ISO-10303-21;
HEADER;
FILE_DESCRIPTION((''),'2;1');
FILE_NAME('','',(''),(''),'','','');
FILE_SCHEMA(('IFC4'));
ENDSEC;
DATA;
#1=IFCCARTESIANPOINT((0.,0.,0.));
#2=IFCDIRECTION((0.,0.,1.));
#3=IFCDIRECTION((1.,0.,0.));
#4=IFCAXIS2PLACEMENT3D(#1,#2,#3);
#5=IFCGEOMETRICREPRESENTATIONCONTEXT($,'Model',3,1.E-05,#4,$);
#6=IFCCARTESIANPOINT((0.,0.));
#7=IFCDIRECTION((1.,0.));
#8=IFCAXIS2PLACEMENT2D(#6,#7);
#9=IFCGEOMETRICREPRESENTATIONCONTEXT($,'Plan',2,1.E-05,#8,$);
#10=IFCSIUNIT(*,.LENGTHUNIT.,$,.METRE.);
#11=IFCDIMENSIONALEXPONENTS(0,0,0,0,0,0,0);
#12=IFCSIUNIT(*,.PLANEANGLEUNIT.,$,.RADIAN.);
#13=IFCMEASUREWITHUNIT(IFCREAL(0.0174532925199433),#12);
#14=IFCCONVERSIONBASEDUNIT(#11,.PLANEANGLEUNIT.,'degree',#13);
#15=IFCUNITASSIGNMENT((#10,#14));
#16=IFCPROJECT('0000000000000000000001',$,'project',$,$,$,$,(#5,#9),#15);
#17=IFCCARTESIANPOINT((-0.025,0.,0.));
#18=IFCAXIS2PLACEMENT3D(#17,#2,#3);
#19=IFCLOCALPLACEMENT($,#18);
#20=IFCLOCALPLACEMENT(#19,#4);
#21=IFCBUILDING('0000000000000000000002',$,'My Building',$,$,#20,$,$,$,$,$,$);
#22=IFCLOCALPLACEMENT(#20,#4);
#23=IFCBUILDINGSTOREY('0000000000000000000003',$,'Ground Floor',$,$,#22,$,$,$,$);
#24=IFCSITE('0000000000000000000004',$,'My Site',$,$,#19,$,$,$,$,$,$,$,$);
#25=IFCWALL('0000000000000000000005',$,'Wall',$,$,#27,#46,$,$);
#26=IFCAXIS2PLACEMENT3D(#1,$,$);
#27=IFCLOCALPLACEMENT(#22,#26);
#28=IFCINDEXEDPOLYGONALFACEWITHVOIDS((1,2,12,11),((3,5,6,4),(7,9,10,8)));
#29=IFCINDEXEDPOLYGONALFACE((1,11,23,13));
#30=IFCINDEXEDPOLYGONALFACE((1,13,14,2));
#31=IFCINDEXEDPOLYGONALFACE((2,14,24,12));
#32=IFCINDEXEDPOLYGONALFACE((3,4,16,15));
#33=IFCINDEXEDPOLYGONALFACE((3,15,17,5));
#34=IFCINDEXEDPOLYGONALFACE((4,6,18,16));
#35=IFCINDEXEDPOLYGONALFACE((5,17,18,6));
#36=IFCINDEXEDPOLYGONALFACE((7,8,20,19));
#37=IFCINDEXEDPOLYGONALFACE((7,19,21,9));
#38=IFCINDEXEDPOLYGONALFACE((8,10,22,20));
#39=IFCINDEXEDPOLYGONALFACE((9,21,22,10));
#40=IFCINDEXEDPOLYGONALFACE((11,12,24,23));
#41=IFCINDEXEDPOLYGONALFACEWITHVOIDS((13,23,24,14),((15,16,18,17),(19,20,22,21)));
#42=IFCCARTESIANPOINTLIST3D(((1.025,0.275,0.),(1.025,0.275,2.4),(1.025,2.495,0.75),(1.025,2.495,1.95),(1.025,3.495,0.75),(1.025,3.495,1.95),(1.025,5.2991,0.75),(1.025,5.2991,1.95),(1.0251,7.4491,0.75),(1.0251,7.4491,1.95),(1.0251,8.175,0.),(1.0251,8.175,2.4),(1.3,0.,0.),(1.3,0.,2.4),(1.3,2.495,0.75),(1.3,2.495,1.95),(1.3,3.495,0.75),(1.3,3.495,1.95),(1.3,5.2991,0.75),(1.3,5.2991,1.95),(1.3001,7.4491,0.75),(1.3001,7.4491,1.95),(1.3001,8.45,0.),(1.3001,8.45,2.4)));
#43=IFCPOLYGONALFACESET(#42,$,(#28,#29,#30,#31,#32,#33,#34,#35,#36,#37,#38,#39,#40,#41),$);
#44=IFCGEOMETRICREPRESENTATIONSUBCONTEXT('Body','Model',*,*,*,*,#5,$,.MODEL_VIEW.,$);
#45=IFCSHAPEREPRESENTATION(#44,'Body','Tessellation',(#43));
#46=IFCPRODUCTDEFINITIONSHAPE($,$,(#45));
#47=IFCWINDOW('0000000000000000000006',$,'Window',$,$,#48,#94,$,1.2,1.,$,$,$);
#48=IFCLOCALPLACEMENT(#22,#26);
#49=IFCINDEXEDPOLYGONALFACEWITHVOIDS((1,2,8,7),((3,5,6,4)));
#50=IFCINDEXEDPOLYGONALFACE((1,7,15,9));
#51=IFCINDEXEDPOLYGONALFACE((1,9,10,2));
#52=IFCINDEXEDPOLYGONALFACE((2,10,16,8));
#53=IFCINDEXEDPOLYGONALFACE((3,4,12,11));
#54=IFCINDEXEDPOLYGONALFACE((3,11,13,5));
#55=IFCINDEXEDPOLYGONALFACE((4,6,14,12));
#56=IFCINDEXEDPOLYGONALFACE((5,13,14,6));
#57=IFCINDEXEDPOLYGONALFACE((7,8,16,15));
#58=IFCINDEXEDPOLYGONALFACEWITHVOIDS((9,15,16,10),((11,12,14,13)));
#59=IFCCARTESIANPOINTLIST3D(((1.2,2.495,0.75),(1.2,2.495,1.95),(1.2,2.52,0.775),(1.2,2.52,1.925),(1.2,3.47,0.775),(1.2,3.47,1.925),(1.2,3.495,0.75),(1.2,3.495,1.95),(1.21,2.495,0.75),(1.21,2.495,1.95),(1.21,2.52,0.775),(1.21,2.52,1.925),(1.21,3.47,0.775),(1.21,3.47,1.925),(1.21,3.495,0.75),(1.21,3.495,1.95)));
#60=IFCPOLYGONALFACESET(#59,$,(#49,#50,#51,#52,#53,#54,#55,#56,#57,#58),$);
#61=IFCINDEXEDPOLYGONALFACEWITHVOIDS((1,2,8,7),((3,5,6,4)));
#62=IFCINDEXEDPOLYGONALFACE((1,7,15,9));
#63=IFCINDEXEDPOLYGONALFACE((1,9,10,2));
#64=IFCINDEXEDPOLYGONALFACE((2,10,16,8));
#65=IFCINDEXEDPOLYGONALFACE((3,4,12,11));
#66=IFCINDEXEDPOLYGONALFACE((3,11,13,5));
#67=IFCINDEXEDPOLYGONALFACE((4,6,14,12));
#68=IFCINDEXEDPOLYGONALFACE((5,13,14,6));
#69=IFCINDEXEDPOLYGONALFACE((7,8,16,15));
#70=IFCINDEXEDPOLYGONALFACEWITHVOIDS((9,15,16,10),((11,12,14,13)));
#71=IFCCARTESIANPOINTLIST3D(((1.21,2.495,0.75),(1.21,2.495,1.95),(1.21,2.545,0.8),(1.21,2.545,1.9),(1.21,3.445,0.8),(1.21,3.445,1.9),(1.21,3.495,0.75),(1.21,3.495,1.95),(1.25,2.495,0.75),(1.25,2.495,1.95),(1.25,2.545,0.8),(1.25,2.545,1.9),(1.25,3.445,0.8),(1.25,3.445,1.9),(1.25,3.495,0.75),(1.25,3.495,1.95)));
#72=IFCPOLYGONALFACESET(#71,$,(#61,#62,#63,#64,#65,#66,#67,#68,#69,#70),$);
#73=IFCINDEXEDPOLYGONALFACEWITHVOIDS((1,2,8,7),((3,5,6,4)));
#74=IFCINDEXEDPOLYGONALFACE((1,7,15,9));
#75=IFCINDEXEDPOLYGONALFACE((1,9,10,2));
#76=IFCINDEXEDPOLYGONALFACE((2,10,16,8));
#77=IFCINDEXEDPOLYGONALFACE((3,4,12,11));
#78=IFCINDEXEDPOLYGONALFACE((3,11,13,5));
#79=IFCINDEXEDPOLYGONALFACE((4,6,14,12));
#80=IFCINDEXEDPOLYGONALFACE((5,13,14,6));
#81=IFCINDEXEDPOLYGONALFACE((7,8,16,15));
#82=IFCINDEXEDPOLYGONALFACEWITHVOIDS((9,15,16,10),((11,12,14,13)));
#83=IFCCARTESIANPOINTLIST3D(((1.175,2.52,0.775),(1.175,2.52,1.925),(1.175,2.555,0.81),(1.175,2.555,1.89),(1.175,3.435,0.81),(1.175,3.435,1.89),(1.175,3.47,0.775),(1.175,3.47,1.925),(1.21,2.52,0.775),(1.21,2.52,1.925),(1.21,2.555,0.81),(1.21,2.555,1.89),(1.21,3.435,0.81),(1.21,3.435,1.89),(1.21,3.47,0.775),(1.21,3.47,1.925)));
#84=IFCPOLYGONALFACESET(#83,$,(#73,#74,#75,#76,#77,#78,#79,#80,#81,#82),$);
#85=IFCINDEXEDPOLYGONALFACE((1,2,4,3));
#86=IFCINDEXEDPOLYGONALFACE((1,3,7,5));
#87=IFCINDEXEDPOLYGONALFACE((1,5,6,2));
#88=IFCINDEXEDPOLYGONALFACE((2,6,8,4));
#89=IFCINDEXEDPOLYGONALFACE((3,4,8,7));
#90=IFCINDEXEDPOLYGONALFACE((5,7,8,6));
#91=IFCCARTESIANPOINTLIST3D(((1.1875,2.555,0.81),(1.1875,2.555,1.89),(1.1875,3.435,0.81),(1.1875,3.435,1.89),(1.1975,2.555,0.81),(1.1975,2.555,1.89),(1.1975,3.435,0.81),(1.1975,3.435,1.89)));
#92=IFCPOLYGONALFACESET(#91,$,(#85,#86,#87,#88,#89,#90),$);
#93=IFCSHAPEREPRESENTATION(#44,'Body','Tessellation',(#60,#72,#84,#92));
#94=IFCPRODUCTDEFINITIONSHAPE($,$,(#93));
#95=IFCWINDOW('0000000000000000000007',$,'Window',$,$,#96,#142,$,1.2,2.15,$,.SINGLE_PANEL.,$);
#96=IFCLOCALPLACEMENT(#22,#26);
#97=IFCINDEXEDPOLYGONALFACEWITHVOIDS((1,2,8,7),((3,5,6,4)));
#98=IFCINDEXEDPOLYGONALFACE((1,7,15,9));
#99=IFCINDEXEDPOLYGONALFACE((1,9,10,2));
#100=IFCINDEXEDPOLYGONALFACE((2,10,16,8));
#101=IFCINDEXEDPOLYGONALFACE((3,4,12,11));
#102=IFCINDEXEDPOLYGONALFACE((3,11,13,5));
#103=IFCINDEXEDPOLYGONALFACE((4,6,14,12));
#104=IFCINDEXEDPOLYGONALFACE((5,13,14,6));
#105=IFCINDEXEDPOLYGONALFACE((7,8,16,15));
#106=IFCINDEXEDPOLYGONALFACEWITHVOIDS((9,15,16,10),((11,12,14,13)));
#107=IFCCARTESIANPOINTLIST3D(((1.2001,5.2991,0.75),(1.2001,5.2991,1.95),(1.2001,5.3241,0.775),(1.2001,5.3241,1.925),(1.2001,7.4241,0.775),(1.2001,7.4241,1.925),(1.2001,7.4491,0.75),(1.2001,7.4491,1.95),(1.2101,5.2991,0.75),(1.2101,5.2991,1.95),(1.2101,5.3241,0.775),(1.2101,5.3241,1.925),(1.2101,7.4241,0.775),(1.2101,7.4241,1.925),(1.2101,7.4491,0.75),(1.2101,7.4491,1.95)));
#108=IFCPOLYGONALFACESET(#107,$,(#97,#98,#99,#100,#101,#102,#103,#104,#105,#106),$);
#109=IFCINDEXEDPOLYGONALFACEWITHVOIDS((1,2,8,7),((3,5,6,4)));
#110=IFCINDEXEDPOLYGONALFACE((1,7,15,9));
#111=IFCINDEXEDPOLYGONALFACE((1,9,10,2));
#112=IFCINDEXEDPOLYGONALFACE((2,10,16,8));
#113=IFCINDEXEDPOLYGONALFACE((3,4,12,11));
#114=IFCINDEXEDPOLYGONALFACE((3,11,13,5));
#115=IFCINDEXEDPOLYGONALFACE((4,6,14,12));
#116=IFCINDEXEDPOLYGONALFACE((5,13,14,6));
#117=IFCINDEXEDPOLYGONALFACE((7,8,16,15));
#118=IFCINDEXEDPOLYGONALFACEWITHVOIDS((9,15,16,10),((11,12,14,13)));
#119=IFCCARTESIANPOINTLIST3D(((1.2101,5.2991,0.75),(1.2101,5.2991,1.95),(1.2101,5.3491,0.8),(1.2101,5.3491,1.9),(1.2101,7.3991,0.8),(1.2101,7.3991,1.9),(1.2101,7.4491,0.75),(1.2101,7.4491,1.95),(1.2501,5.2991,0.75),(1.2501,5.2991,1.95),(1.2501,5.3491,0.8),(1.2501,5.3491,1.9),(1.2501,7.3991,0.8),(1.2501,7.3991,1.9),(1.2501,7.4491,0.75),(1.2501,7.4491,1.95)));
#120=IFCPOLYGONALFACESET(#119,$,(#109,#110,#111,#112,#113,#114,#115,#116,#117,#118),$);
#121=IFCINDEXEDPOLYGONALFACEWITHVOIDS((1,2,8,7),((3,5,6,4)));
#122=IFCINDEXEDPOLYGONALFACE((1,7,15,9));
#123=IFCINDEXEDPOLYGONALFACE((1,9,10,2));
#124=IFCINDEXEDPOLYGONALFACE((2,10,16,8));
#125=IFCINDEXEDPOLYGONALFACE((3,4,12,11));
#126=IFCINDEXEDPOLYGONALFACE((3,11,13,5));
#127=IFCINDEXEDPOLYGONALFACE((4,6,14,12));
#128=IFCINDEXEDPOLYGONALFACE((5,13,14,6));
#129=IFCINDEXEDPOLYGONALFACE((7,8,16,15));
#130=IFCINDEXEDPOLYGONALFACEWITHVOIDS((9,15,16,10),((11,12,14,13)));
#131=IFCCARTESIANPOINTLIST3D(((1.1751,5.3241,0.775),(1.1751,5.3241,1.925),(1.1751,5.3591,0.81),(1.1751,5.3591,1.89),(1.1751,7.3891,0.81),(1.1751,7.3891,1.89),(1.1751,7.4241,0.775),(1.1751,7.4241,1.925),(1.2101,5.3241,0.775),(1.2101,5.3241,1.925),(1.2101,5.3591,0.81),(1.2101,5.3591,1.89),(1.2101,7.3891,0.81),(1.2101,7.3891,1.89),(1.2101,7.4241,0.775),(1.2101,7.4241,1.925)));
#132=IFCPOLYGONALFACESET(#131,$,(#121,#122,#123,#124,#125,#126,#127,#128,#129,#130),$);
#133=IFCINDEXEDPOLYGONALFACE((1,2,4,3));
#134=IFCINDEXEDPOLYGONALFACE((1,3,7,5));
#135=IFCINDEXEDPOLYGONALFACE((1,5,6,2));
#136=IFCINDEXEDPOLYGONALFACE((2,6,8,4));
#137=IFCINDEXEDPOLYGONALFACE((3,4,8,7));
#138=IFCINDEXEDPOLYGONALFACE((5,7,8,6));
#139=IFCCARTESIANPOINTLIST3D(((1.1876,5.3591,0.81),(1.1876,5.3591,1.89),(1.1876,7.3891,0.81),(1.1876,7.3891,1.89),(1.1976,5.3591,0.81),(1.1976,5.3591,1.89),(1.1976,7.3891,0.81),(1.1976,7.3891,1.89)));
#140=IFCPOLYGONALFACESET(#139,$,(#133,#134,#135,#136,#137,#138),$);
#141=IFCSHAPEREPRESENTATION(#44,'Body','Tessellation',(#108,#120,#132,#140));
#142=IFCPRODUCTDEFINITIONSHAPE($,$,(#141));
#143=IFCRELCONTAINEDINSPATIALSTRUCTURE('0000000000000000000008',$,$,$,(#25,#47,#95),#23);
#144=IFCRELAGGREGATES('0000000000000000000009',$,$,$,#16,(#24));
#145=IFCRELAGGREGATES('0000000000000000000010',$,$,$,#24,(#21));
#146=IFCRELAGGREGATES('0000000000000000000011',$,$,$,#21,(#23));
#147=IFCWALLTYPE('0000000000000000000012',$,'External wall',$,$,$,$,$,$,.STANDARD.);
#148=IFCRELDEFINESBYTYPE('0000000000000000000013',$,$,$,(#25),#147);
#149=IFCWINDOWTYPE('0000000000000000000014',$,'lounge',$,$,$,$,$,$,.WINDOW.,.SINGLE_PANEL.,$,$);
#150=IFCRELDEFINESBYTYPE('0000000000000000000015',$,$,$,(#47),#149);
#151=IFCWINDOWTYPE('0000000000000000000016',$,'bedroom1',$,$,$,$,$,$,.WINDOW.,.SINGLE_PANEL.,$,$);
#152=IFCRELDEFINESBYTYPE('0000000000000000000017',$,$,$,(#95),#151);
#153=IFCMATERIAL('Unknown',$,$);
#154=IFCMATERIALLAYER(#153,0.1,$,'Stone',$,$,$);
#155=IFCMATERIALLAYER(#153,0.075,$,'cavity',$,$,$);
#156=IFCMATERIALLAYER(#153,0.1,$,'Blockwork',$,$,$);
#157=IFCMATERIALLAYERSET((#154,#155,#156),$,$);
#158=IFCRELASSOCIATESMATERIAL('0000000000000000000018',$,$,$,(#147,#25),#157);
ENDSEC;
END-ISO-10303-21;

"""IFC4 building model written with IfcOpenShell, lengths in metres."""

from ifc_helpers import new_model, entity, si_unit, converted_unit, frame, origin_with_axes, origin_2d_with_axis, place, context, subcontext, project, spatial, line, indexed_curve, outline, extrude, clip, halfspace, shape, source, transform, mapped, material, layer, layer_set, layer_usage, type_object, type_shapes, element, fill, save


model = new_model("IFC4")

# Units and contexts
model_context = context("Model", 3, precision=1e-05, world=origin_with_axes())
plan_context = context("Plan", 2, precision=1e-05, world=origin_2d_with_axis())
body_context_1 = subcontext(model_context, "Body", "Model", "MODEL_VIEW")
body_context_2 = subcontext(plan_context, "Body", "Plan", "PLAN_VIEW")
ifc_project = project(units=[si_unit("LENGTHUNIT", "METRE"), converted_unit("PLANEANGLEUNIT", "degree", entity("IfcReal", 0.0174532925199433), si_unit("PLANEANGLEUNIT", "RADIAN"), dimensions=[0, 0, 0, 0, 0, 0, 0])], contexts=[model_context, plan_context])

# Site, building, storey
site_placement = place(None, frame((-0.025, 0.0, 0.0), z_axis=(0.0, 0.0, 1.0), x_axis=(1.0, 0.0, 0.0)))
site = spatial("IfcSite", under=ifc_project, at=site_placement, Name="My Site")
building_placement = place(site_placement, origin_with_axes())
building = spatial("IfcBuilding", under=site, at=building_placement, Name="My Building")
storey_placement = place(building_placement, frame((0.0, 0.0, 0.0), z_axis=(0.0, 0.0, 1.0), x_axis=(1.0, 0.0, 0.0)))
storey = spatial("IfcBuildingStorey", under=building, at=storey_placement, Name="Ground Floor")

# Shared definitions
ifc_material = material(Name="Unknown")
ifc_layer_1 = layer(ifc_material, 0.1, Name="Stone")
ifc_layer_2 = layer(ifc_material, 0.075, Name="cavity")
ifc_layer_3 = layer(ifc_material, 0.1, Name="Blockwork")
ifc_layer_set_1 = layer_set([ifc_layer_1, ifc_layer_2, ifc_layer_3])
wall_type_1 = type_object("IfcWallType", Name="External wall", PredefinedType="STANDARD", material=ifc_layer_set_1)

# Wall, openings, windows
ifc_layer_usage_1 = layer_usage(ifc_layer_set_1, "AXIS2", "POSITIVE", 0.0)
wall_1_placement = place(storey_placement, frame((1.3, 0.0, 0.0), z_axis=(0.0, 0.0, 1.0), x_axis=(0.0, 1.0, 0.0)))
wall_1 = element("IfcWall", 1, at=wall_1_placement, inside=storey, type_object=wall_type_1, material=ifc_layer_usage_1, Name="Wall", context=body_context_1, shape_type="Clipping", body=[
    clip(clip(extrude(outline(indexed_curve([(0.0, 0.0), (0.0, 0.275), (8.45, 0.275), (8.45, 0.0), (0.0, 0.0)], self_intersect=False)), origin_with_axes(), (0.0, 0.0, 1.0), 2.4), halfspace(frame((0.0, 0.0, 0.0), z_axis=(-0.707107, 0.707107, 0.0), x_axis=(0.707107, 0.707107, 0.0)), False)), halfspace(frame((8.45, 0.0, 0.0), z_axis=(0.707107, 0.707106, 0.0), x_axis=(-0.707106, 0.707107, 0.0)), False)),
])
shared_shape_1 = source(origin_with_axes(), body_context_1, "Body", "SweptSolid", [
    extrude(outline(indexed_curve([(0.0, 0.0), (1.0, 0.0), (1.0, 1.2), (0.0, 1.2)], segments=[line(1, 2, 3, 4, 1)])), frame((0.0, -0.6, 0.0), z_axis=(0.0, -1.0, 0.0), x_axis=(1.0, 0.0, 0.0)), (0.0, 0.0, -1.0), 1.2),
])
opening_1_placement = place(wall_1_placement, frame((2.495, 0.0, 0.75), z_axis=(0.0, 0.0, 1.0), x_axis=(1.0, 0.0, 0.0)))
opening_1 = element("IfcOpeningElement", 2, at=opening_1_placement, cuts=wall_1, PredefinedType="OPENING", context=body_context_1, shape_type="MappedRepresentation", body=[
    mapped(shared_shape_1, transform((0.0, 0.0, 0.0), x_axis=(1.0, 0.0, 0.0), y_axis=(0.0, 1.0, 0.0), z_axis=(0.0, 0.0, 1.0), scale=1.0)),
])
shared_shape_2 = source(origin_with_axes(), body_context_1, "Body", "SweptSolid", [
    extrude(outline(indexed_curve([(0.0, 0.0), (2.15, 0.0), (2.15, 1.2), (0.0, 1.2)], segments=[line(1, 2, 3, 4, 1)])), frame((0.0, -0.1, 0.0), z_axis=(0.0, -1.0, 0.0), x_axis=(1.0, 0.0, 0.0)), (0.0, 0.0, -1.0), 0.475),
])
opening_2_placement = place(wall_1_placement, frame((5.2991, 0.0, 0.75), z_axis=(0.0, 0.0, 1.0), x_axis=(1.0, 0.0, 0.0)))
opening_2 = element("IfcOpeningElement", 3, at=opening_2_placement, cuts=wall_1, PredefinedType="OPENING", context=body_context_1, shape_type="MappedRepresentation", body=[
    mapped(shared_shape_2, transform((0.0, 0.0, 0.0), x_axis=(1.0, 0.0, 0.0), y_axis=(0.0, 1.0, 0.0), z_axis=(0.0, 0.0, 1.0), scale=1.0)),
])
window_type_1 = type_object("IfcWindowType", Name="lounge", PartitioningType="SINGLE_PANEL", PredefinedType="WINDOW")
shared_shape_3 = source(origin_with_axes(), body_context_1, "Body", "SweptSolid", [
    extrude(outline(indexed_curve([(0.0, 0.0), (1.0, 0.0), (1.0, 1.2), (0.0, 1.2)], segments=[line(1, 2, 3, 4, 1)]), holes=[indexed_curve([(0.025, 0.025), (0.975, 0.025), (0.975, 1.175), (0.025, 1.175)], segments=[line(1, 2, 3, 4, 1)])]), frame((0.0, 0.09, 0.0), z_axis=(0.0, -1.0, 0.0), x_axis=(1.0, 0.0, 0.0)), (0.0, 0.0, -1.0), 0.01),
    extrude(outline(indexed_curve([(0.0, 0.0), (1.0, 0.0), (1.0, 1.2), (0.0, 1.2)], segments=[line(1, 2, 3, 4, 1)]), holes=[indexed_curve([(0.05, 0.05), (0.95, 0.05), (0.95, 1.15), (0.05, 1.15)], segments=[line(1, 2, 3, 4, 1)])]), frame((0.0, 0.05, 0.0), z_axis=(0.0, -1.0, 0.0), x_axis=(1.0, 0.0, 0.0)), (0.0, 0.0, -1.0), 0.04),
    extrude(outline(indexed_curve([(0.0, 0.0), (0.95, 0.0), (0.95, 1.15), (0.0, 1.15)], segments=[line(1, 2, 3, 4, 1)]), holes=[indexed_curve([(0.035, 0.035), (0.915, 0.035), (0.915, 1.115), (0.035, 1.115)], segments=[line(1, 2, 3, 4, 1)])]), frame((0.025, 0.09, 0.025), z_axis=(0.0, -1.0, 0.0), x_axis=(1.0, 0.0, 0.0)), (0.0, 0.0, -1.0), 0.035),
    extrude(outline(indexed_curve([(0.035, 0.035), (0.915, 0.035), (0.915, 1.115), (0.035, 1.115)], segments=[line(1, 2, 3, 4, 1)])), frame((0.025, 0.1025, 0.025), z_axis=(0.0, -1.0, 0.0), x_axis=(1.0, 0.0, 0.0)), (0.0, 0.0, -1.0), 0.01),
])
shared_shape_4 = source(origin_with_axes(), body_context_2, "Body", "Curve2D", [
    entity("IfcIndexedPolyCurve", entity("IfcCartesianPointList2D", [[0.05, 0.05], [0.95, 0.05]])),
    entity("IfcIndexedPolyCurve", entity("IfcCartesianPointList2D", [[0.0, 0.1], [0.025, 0.1], [0.025, 0.09], [0.05, 0.09], [0.05, 0.05], [0.0, 0.05]]), [entity("IfcLineIndex", [1, 2, 3, 4, 5, 6, 1])]),
    entity("IfcIndexedPolyCurve", entity("IfcCartesianPointList2D", [[1.0, 0.1], [0.975, 0.1], [0.975, 0.09], [0.95, 0.09], [0.95, 0.05], [1.0, 0.05]]), [entity("IfcLineIndex", [1, 2, 3, 4, 5, 6, 1])]),
    entity("IfcIndexedPolyCurve", entity("IfcCartesianPointList2D", [[0.025, 0.09], [0.06, 0.09], [0.06, 0.125], [0.025, 0.125]]), [entity("IfcLineIndex", [1, 2, 3, 4, 1])]),
    entity("IfcIndexedPolyCurve", entity("IfcCartesianPointList2D", [[0.975, 0.09], [0.94, 0.09], [0.94, 0.125], [0.975, 0.125]]), [entity("IfcLineIndex", [1, 2, 3, 4, 1])]),
    entity("IfcIndexedPolyCurve", entity("IfcCartesianPointList2D", [[0.06, 0.09], [0.94, 0.09]])),
    entity("IfcIndexedPolyCurve", entity("IfcCartesianPointList2D", [[0.06, 0.125], [0.94, 0.125]])),
    entity("IfcIndexedPolyCurve", entity("IfcCartesianPointList2D", [[0.06, 0.1075], [0.94, 0.1075]])),
])
type_shapes(window_type_1, [shared_shape_3, shared_shape_4])
window_1_placement = place(opening_1_placement, frame((0.0, 0.0, 0.0), z_axis=(0.0, 0.0, 1.0), x_axis=(1.0, 0.0, 0.0)))
window_1 = element("IfcWindow", 4, at=window_1_placement, inside=storey, type_object=window_type_1, Name="Window", OverallHeight=1.2, OverallWidth=1.0, shapes=[
    shape(body_context_1, "Body", "MappedRepresentation", [mapped(shared_shape_3, transform((0.0, 0.0, 0.0), x_axis=(1.0, 0.0, 0.0), y_axis=(0.0, 1.0, 0.0), z_axis=(0.0, 0.0, 1.0), scale=1.0))]),
    shape(body_context_2, "Body", "MappedRepresentation", [mapped(shared_shape_4, transform((0.0, 0.0, 0.0), x_axis=(1.0, 0.0, 0.0), y_axis=(0.0, 1.0, 0.0), z_axis=(0.0, 0.0, 1.0), scale=1.0))]),
])
fill(opening_1, window_1)
window_type_2 = type_object("IfcWindowType", Name="bedroom1", PartitioningType="SINGLE_PANEL", PredefinedType="WINDOW")
shared_shape_5 = source(origin_with_axes(), body_context_1, "Body", "SweptSolid", [
    extrude(outline(indexed_curve([(0.0, 0.0), (2.15, 0.0), (2.15, 1.2), (0.0, 1.2)], segments=[line(1, 2, 3, 4, 1)]), holes=[indexed_curve([(0.025, 0.025), (2.125, 0.025), (2.125, 1.175), (0.025, 1.175)], segments=[line(1, 2, 3, 4, 1)])]), frame((0.0, 0.09, 0.0), z_axis=(0.0, -1.0, 0.0), x_axis=(1.0, 0.0, 0.0)), (0.0, 0.0, -1.0), 0.01),
    extrude(outline(indexed_curve([(0.0, 0.0), (2.15, 0.0), (2.15, 1.2), (0.0, 1.2)], segments=[line(1, 2, 3, 4, 1)]), holes=[indexed_curve([(0.05, 0.05), (2.1, 0.05), (2.1, 1.15), (0.05, 1.15)], segments=[line(1, 2, 3, 4, 1)])]), frame((0.0, 0.05, 0.0), z_axis=(0.0, -1.0, 0.0), x_axis=(1.0, 0.0, 0.0)), (0.0, 0.0, -1.0), 0.04),
    extrude(outline(indexed_curve([(0.0, 0.0), (2.1, 0.0), (2.1, 1.15), (0.0, 1.15)], segments=[line(1, 2, 3, 4, 1)]), holes=[indexed_curve([(0.035, 0.035), (2.065, 0.035), (2.065, 1.115), (0.035, 1.115)], segments=[line(1, 2, 3, 4, 1)])]), frame((0.025, 0.09, 0.025), z_axis=(0.0, -1.0, 0.0), x_axis=(1.0, 0.0, 0.0)), (0.0, 0.0, -1.0), 0.035),
    extrude(outline(indexed_curve([(0.035, 0.035), (2.065, 0.035), (2.065, 1.115), (0.035, 1.115)], segments=[line(1, 2, 3, 4, 1)])), frame((0.025, 0.1025, 0.025), z_axis=(0.0, -1.0, 0.0), x_axis=(1.0, 0.0, 0.0)), (0.0, 0.0, -1.0), 0.01),
])
shared_shape_6 = source(origin_with_axes(), body_context_2, "Body", "Curve2D", [
    entity("IfcIndexedPolyCurve", entity("IfcCartesianPointList2D", [[0.05, 0.05], [2.1, 0.05]])),
    entity("IfcIndexedPolyCurve", entity("IfcCartesianPointList2D", [[0.0, 0.1], [0.025, 0.1], [0.025, 0.09], [0.05, 0.09], [0.05, 0.05], [0.0, 0.05]]), [entity("IfcLineIndex", [1, 2, 3, 4, 5, 6, 1])]),
    entity("IfcIndexedPolyCurve", entity("IfcCartesianPointList2D", [[2.15, 0.1], [2.125, 0.1], [2.125, 0.09], [2.1, 0.09], [2.1, 0.05], [2.15, 0.05]]), [entity("IfcLineIndex", [1, 2, 3, 4, 5, 6, 1])]),
    entity("IfcIndexedPolyCurve", entity("IfcCartesianPointList2D", [[0.025, 0.09], [0.06, 0.09], [0.06, 0.125], [0.025, 0.125]]), [entity("IfcLineIndex", [1, 2, 3, 4, 1])]),
    entity("IfcIndexedPolyCurve", entity("IfcCartesianPointList2D", [[2.125, 0.09], [2.09, 0.09], [2.09, 0.125], [2.125, 0.125]]), [entity("IfcLineIndex", [1, 2, 3, 4, 1])]),
    entity("IfcIndexedPolyCurve", entity("IfcCartesianPointList2D", [[0.06, 0.09], [2.09, 0.09]])),
    entity("IfcIndexedPolyCurve", entity("IfcCartesianPointList2D", [[0.06, 0.125], [2.09, 0.125]])),
    entity("IfcIndexedPolyCurve", entity("IfcCartesianPointList2D", [[0.06, 0.1075], [2.09, 0.1075]])),
])
type_shapes(window_type_2, [shared_shape_5, shared_shape_6])
window_2_placement = place(opening_2_placement, frame((0.0, 0.0, 0.0), z_axis=(0.0, 0.0, 1.0), x_axis=(1.0, 0.0, 0.0)))
window_2 = element("IfcWindow", 5, at=window_2_placement, inside=storey, type_object=window_type_2, Name="Window", OverallHeight=1.2, OverallWidth=2.15, PartitioningType="SINGLE_PANEL", shapes=[
    shape(body_context_1, "Body", "MappedRepresentation", [mapped(shared_shape_5, transform((0.0, 0.0, 0.0), x_axis=(1.0, 0.0, 0.0), y_axis=(0.0, 1.0, 0.0), z_axis=(0.0, 0.0, 1.0), scale=1.0))]),
    shape(body_context_2, "Body", "MappedRepresentation", [mapped(shared_shape_6, transform((0.0, 0.0, 0.0), x_axis=(1.0, 0.0, 0.0), y_axis=(0.0, 1.0, 0.0), z_axis=(0.0, 0.0, 1.0), scale=1.0))]),
])
fill(opening_2, window_2)

save(model, "model.ifc")
